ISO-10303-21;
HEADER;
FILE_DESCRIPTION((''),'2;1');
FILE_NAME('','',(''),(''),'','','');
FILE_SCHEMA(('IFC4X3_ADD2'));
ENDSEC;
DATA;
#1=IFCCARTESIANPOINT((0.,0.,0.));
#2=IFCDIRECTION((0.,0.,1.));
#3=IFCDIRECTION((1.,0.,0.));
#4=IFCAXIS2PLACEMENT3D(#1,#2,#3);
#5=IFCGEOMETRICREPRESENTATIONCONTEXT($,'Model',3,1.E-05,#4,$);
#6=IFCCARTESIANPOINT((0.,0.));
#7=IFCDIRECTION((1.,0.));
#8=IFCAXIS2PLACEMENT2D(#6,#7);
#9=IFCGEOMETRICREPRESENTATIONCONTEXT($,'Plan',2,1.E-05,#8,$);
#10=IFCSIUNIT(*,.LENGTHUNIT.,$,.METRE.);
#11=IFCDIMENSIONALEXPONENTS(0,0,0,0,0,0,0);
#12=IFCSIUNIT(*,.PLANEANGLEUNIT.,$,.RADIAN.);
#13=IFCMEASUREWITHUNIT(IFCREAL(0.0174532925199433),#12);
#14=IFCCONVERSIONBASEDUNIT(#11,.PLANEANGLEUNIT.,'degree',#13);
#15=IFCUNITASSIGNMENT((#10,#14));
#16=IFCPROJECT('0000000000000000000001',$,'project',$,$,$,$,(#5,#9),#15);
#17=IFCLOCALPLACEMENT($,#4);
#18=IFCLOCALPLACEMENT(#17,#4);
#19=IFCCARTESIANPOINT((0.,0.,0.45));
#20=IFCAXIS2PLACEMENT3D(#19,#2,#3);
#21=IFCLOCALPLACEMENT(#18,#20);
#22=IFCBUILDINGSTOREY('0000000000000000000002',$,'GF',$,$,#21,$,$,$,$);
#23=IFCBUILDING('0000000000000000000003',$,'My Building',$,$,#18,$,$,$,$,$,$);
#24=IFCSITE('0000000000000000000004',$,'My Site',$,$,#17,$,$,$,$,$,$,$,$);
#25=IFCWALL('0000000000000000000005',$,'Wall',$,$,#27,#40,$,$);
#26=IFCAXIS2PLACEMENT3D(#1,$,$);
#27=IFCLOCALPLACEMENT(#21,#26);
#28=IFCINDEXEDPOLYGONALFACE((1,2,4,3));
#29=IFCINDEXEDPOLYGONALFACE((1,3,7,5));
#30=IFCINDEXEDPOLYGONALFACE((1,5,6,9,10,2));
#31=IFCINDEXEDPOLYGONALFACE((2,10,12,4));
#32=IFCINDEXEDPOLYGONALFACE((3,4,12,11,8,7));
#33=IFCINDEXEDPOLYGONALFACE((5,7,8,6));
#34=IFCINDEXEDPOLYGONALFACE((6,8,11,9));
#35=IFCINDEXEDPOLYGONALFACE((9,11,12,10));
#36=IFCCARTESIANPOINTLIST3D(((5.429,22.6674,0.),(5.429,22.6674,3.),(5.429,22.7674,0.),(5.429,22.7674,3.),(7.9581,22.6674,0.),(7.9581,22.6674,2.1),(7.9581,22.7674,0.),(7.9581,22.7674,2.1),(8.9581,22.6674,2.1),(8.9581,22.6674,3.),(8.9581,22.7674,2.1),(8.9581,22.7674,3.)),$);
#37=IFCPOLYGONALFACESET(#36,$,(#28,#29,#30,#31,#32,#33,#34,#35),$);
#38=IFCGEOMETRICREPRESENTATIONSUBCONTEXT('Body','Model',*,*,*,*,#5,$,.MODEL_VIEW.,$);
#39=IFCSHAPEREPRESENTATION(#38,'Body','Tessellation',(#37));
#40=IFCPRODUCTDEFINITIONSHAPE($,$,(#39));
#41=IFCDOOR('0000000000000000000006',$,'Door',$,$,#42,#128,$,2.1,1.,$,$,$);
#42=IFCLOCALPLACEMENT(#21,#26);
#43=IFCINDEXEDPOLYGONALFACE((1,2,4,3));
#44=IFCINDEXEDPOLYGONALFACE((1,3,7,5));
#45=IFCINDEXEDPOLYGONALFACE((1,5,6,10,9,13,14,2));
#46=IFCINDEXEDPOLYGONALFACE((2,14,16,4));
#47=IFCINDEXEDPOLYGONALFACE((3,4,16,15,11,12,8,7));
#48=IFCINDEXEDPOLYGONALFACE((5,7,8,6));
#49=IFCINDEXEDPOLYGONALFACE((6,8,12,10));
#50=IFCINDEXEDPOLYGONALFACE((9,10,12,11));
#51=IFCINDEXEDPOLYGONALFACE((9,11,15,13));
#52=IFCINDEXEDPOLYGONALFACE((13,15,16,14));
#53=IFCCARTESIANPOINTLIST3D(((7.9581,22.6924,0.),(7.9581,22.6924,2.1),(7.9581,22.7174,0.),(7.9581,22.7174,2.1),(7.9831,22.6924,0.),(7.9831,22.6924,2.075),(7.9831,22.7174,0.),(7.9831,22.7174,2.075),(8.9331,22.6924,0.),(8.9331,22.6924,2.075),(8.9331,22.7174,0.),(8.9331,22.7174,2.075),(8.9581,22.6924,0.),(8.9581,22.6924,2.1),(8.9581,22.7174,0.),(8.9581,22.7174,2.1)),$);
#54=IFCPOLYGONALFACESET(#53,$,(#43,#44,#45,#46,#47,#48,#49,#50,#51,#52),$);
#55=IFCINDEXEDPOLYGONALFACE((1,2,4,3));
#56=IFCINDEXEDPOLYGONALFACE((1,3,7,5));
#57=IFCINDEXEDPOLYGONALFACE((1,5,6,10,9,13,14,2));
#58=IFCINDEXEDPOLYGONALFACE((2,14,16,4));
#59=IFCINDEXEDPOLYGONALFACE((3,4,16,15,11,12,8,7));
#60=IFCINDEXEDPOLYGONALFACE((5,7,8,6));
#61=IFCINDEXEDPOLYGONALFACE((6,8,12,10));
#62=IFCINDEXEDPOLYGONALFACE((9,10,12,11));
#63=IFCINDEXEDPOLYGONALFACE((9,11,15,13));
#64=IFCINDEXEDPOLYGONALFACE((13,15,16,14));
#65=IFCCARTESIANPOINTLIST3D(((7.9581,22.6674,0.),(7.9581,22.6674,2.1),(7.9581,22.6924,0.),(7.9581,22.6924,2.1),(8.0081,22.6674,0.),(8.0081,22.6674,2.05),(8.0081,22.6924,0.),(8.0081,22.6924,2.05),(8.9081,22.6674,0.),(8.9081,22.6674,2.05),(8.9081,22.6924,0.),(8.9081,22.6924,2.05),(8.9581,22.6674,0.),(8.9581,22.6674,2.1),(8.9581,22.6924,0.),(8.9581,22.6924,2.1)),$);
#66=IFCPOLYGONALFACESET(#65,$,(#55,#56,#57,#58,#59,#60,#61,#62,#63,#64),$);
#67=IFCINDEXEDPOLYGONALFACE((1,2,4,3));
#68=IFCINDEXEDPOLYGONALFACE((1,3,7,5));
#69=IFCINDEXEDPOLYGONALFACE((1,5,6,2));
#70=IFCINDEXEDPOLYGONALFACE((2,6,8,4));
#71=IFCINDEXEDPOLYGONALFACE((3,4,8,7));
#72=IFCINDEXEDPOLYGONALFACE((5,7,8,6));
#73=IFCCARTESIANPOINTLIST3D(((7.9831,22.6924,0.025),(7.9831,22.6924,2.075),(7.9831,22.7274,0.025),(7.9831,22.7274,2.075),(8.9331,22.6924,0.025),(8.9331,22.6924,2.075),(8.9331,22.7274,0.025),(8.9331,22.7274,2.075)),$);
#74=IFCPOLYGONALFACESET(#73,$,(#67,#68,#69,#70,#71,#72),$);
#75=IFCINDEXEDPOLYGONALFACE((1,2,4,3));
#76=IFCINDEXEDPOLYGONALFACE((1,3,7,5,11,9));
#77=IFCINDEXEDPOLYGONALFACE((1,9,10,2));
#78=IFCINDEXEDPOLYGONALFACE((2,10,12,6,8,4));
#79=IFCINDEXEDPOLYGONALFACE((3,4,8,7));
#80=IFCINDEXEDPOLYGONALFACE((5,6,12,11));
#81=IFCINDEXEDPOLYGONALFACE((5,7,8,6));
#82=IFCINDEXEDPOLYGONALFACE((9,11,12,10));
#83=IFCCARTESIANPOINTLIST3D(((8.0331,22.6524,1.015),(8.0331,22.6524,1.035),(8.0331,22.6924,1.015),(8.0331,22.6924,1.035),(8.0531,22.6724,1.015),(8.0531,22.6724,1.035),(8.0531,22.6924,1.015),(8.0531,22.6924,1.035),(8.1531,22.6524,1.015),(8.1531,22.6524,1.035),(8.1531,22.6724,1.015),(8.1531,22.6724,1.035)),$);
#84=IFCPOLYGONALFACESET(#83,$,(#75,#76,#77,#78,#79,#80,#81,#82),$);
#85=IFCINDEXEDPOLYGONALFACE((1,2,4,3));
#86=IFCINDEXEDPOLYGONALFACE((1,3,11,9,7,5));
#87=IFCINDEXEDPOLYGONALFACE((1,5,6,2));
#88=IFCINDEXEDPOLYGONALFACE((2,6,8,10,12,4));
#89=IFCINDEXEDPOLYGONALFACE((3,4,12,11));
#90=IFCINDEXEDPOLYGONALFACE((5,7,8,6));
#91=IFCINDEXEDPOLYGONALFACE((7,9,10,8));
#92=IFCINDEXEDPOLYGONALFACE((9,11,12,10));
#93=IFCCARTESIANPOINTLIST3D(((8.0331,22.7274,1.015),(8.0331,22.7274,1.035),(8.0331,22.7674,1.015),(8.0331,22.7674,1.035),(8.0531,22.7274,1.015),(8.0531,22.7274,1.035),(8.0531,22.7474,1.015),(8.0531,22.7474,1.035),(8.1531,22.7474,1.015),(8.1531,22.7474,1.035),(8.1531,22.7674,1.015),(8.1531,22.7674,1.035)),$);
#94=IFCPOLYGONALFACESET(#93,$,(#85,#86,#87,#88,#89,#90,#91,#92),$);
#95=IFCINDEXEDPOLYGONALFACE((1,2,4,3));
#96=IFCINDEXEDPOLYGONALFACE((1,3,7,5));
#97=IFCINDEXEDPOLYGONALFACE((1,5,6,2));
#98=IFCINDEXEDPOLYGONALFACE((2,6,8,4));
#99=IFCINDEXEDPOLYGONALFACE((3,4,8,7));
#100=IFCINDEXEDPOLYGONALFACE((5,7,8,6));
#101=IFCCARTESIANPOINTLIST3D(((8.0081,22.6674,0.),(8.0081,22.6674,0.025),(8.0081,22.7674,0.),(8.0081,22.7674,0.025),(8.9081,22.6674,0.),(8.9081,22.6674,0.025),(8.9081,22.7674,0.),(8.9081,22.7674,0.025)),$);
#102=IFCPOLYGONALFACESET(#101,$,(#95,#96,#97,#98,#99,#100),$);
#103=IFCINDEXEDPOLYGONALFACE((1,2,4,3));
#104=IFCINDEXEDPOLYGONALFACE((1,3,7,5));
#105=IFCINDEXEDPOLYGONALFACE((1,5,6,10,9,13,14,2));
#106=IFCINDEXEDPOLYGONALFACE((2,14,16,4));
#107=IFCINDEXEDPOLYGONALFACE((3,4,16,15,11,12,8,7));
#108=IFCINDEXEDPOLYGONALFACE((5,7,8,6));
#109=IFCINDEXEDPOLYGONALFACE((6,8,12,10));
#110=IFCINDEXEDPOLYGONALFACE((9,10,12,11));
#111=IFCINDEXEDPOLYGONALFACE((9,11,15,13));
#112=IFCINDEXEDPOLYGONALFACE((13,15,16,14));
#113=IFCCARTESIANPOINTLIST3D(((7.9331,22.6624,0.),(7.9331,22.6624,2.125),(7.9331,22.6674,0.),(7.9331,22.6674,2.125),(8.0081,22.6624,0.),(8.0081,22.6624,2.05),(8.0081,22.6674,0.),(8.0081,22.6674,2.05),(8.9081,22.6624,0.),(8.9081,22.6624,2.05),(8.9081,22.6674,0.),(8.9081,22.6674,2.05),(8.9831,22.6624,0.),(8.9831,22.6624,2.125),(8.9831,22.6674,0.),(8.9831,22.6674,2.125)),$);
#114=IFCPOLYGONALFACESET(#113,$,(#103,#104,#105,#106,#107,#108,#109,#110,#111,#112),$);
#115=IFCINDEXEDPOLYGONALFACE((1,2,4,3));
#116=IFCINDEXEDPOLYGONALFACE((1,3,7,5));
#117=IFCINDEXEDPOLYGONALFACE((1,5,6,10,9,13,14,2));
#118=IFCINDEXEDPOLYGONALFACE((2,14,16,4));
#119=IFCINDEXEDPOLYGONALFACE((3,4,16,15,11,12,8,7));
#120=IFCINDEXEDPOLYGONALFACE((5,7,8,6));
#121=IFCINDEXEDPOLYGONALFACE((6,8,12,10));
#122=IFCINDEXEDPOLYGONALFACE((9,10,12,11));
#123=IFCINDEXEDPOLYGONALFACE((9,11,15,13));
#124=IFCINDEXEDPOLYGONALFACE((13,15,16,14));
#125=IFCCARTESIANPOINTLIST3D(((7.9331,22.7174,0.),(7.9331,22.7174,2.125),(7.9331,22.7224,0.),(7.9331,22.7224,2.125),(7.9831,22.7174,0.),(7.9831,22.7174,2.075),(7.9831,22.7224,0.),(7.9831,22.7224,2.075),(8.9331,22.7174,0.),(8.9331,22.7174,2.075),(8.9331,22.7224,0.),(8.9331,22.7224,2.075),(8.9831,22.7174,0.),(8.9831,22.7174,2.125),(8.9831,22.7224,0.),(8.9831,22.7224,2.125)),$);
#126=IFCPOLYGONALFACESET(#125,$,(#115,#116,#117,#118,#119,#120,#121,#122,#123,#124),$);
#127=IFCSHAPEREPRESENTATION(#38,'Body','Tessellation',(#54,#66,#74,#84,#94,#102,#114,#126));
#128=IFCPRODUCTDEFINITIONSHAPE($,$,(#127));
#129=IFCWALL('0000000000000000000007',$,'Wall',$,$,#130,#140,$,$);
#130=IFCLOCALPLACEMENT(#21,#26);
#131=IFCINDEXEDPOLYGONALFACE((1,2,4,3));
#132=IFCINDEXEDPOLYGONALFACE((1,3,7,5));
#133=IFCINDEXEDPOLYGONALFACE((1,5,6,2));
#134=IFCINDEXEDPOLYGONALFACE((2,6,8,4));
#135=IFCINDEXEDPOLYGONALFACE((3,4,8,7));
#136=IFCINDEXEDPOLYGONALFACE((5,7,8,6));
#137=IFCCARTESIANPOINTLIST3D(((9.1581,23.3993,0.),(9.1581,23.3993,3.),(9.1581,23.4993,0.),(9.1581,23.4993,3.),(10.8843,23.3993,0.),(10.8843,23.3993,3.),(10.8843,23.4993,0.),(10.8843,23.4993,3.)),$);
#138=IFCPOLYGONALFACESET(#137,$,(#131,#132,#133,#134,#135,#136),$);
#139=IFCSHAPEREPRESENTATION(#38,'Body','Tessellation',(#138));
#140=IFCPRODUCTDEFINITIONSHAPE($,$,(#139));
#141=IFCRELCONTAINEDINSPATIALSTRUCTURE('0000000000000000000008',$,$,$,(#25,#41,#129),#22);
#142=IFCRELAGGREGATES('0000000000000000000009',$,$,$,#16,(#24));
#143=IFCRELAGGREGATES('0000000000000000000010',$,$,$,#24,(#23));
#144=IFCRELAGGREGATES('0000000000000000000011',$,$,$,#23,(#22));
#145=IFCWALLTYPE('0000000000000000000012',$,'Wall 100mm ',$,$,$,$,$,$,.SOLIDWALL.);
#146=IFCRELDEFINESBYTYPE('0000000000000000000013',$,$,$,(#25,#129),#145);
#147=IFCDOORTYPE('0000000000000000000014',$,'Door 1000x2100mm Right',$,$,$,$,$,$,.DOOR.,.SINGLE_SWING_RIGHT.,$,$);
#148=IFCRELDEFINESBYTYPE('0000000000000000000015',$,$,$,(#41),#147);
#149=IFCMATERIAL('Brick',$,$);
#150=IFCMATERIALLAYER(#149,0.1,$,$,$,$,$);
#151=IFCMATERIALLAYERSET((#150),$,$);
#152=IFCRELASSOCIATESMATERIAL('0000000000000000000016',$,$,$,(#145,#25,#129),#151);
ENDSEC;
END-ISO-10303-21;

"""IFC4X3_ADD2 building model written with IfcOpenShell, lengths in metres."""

from ifc_helpers import new_model, entity, si_unit, converted_unit, frame, origin_with_axes, origin_2d_with_axis, place, context, subcontext, project, spatial, line, indexed_curve, outline, extrude, shape, source, transform, mapped, material, layer, layer_set, layer_usage, type_object, type_shapes, element, fill, save


model = new_model("IFC4X3_ADD2")

# Units and contexts
model_context = context("Model", 3, precision=1e-05, world=origin_with_axes())
plan_context = context("Plan", 2, precision=1e-05, world=origin_2d_with_axis())
body_context_1 = subcontext(model_context, "Body", "Model", "MODEL_VIEW")
body_context_2 = subcontext(plan_context, "Body", "Plan", "PLAN_VIEW")
ifc_project = project(units=[si_unit("LENGTHUNIT", "METRE"), converted_unit("PLANEANGLEUNIT", "degree", entity("IfcReal", 0.0174532925199433), si_unit("PLANEANGLEUNIT", "RADIAN"), dimensions=[0, 0, 0, 0, 0, 0, 0])], contexts=[model_context, plan_context])

# Site, building, storey
site_placement = place(None, origin_with_axes())
site = spatial("IfcSite", under=ifc_project, at=site_placement, Name="My Site")
building_placement = place(site_placement, origin_with_axes())
building = spatial("IfcBuilding", under=site, at=building_placement, Name="My Building")
storey_placement = place(building_placement, frame((0.0, 0.0, 0.45), z_axis=(0.0, 0.0, 1.0), x_axis=(1.0, 0.0, 0.0)))
storey = spatial("IfcBuildingStorey", under=building, at=storey_placement, Name="GF")

# Shared definitions
ifc_material = material(Name="Brick")

# Wall, opening, door
ifc_layer_1 = layer(ifc_material, 0.1)
ifc_layer_set_1 = layer_set([ifc_layer_1])
ifc_layer_usage_1 = layer_usage(ifc_layer_set_1, "AXIS2", "POSITIVE", 0.0)
wall_type_1 = type_object("IfcWallType", Name="Wall 100mm ", PredefinedType="SOLIDWALL", material=ifc_layer_set_1)
wall_1_placement = place(storey_placement, frame((5.429, 22.6674, 0.0), z_axis=(0.0, 0.0, 1.0), x_axis=(1.0, 0.0, 0.0)))
wall_1 = element("IfcWall", 1, at=wall_1_placement, inside=storey, type_object=wall_type_1, material=ifc_layer_usage_1, Name="Wall", context=body_context_1, shape_type="SweptSolid", body=[
    extrude(outline(indexed_curve([(0.0, 0.0), (0.0, 0.1), (3.5291, 0.1), (3.5291, 0.0), (0.0, 0.0)], self_intersect=False)), origin_with_axes(), (0.0, 0.0, 1.0), 3.0),
])
shared_shape_1 = source(origin_with_axes(), body_context_1, "Body", "SweptSolid", [
    extrude(outline(indexed_curve([(0.0, 0.0), (1.0, 0.0), (1.0, 2.1), (0.0, 2.1)], segments=[line(1, 2, 3, 4, 1)])), frame((0.0, -0.6, 0.0), z_axis=(0.0, -1.0, 0.0), x_axis=(1.0, 0.0, 0.0)), (0.0, 0.0, -1.0), 1.2),
])
opening_1_placement = place(wall_1_placement, frame((2.5291, 0.0, 0.0), z_axis=(0.0, 0.0, 1.0), x_axis=(1.0, 0.0, 0.0)))
opening_1 = element("IfcOpeningElement", 2, at=opening_1_placement, cuts=wall_1, PredefinedType="OPENING", context=body_context_1, shape_type="MappedRepresentation", body=[
    mapped(shared_shape_1, transform((0.0, 0.0, 0.0), x_axis=(1.0, 0.0, 0.0), y_axis=(0.0, 1.0, 0.0), z_axis=(0.0, 0.0, 1.0), scale=1.0)),
])
door_type_1 = type_object("IfcDoorType", Name="Door 1000x2100mm Right", OperationType="SINGLE_SWING_RIGHT", PredefinedType="DOOR")
shared_shape_2 = source(origin_with_axes(), body_context_1, "Body", "SweptSolid", [
    extrude(outline(indexed_curve([(0.0, 0.0), (0.0, 2.1), (1.0, 2.1), (1.0, 0.0), (0.975, 0.0), (0.975, 2.075), (0.025, 2.075), (0.025, 0.0)], segments=[line(1, 2, 3, 4, 5, 6, 7, 8, 1)])), frame((0.0, 0.025, 0.0), z_axis=(0.0, -1.0, 0.0), x_axis=(1.0, 0.0, 0.0)), (0.0, 0.0, -1.0), 0.025),
    extrude(outline(indexed_curve([(0.0, 0.0), (0.0, 2.1), (1.0, 2.1), (1.0, 0.0), (0.95, 0.0), (0.95, 2.05), (0.05, 2.05), (0.05, 0.0)], segments=[line(1, 2, 3, 4, 5, 6, 7, 8, 1)])), frame((0.0, 0.0, 0.0), z_axis=(0.0, -1.0, 0.0), x_axis=(1.0, 0.0, 0.0)), (0.0, 0.0, -1.0), 0.025),
    extrude(outline(indexed_curve([(0.0, 0.0), (0.95, 0.0), (0.95, 0.035), (0.0, 0.035)], segments=[line(1, 2, 3, 4, 1)])), frame((0.025, 0.025, 0.025), z_axis=(0.0, 0.0, 1.0), x_axis=(1.0, 0.0, 0.0)), (0.0, 0.0, 1.0), 2.05),
    extrude(outline(indexed_curve([(0.0, 0.0), (0.0, -0.04), (0.12, -0.04), (0.12, -0.02), (0.02, -0.02), (0.02, 0.0)], segments=[line(1, 2, 3, 4, 5, 6, 1)])), frame((0.075, 0.025, 1.015), z_axis=(0.0, 0.0, 1.0), x_axis=(1.0, 0.0, 0.0)), (0.0, 0.0, 1.0), 0.02),
    extrude(outline(indexed_curve([(0.0, 0.0), (0.0, 0.04), (0.12, 0.04), (0.12, 0.02), (0.02, 0.02), (0.02, 0.0)], segments=[line(1, 2, 3, 4, 5, 6, 1)])), frame((0.075, 0.06, 1.015), z_axis=(0.0, 0.0, 1.0), x_axis=(1.0, 0.0, 0.0)), (0.0, 0.0, 1.0), 0.02),
    extrude(outline(indexed_curve([(0.0, 0.0), (0.9, 0.0), (0.9, 0.1), (0.0, 0.1)], segments=[line(1, 2, 3, 4, 1)])), frame((0.05, 0.0, 0.0), z_axis=(0.0, 0.0, 1.0), x_axis=(1.0, 0.0, 0.0)), (0.0, 0.0, 1.0), 0.025),
    extrude(outline(indexed_curve([(0.0, 0.0), (0.0, 2.125), (1.05, 2.125), (1.05, 0.0), (0.975, 0.0), (0.975, 2.05), (0.075, 2.05), (0.075, 0.0)], segments=[line(1, 2, 3, 4, 5, 6, 7, 8, 1)])), frame((-0.025, -0.005, 0.0), z_axis=(0.0, -1.0, 0.0), x_axis=(1.0, 0.0, 0.0)), (0.0, 0.0, -1.0), 0.005),
    extrude(outline(indexed_curve([(0.0, 0.0), (0.0, 2.125), (1.05, 2.125), (1.05, 0.0), (1.0, 0.0), (1.0, 2.075), (0.05, 2.075), (0.05, 0.0)], segments=[line(1, 2, 3, 4, 5, 6, 7, 8, 1)])), frame((-0.025, 0.05, 0.0), z_axis=(0.0, -1.0, 0.0), x_axis=(1.0, 0.0, 0.0)), (0.0, 0.0, -1.0), 0.005),
])
shared_shape_3 = source(origin_with_axes(), body_context_2, "Body", "Curve2D", [
    entity("IfcIndexedPolyCurve", entity("IfcCartesianPointList2D", [[0.0, 0.0], [0.0, 0.05], [0.025, 0.05], [0.025, 0.025], [0.05, 0.025], [0.05, 0.0]]), [entity("IfcLineIndex", [1, 2, 3, 4, 5, 6, 1])]),
    entity("IfcIndexedPolyCurve", entity("IfcCartesianPointList2D", [[1.0, 0.0], [1.0, 0.05], [0.975, 0.05], [0.975, 0.025], [0.95, 0.025], [0.95, 0.0]]), [entity("IfcLineIndex", [1, 2, 3, 4, 5, 6, 1])]),
    entity("IfcTrimmedCurve", entity("IfcEllipse", entity("IfcAxis2Placement2D", entity("IfcCartesianPoint", [0.94, 0.05]), entity("IfcDirection", [1.0, 0.0])), 0.915, 0.95), [entity("IfcCartesianPoint", [0.94, 1.0])], [entity("IfcCartesianPoint", [0.025, 0.05])], True, "CARTESIAN"),
    entity("IfcIndexedPolyCurve", entity("IfcCartesianPointList2D", [[0.975, 0.05], [0.94, 0.05], [0.94, 1.0], [0.975, 1.0]]), [entity("IfcLineIndex", [1, 2, 3, 4, 1])]),
])
type_shapes(door_type_1, [shared_shape_2, shared_shape_3])
door_1_placement = place(opening_1_placement, origin_with_axes())
door_1 = element("IfcDoor", 3, at=door_1_placement, inside=storey, type_object=door_type_1, Name="Door", OverallHeight=2.1, OverallWidth=1.0, shapes=[
    shape(body_context_1, "Body", "MappedRepresentation", [mapped(shared_shape_2, transform((0.0, 0.0, 0.0), x_axis=(1.0, 0.0, 0.0), y_axis=(0.0, 1.0, 0.0), z_axis=(0.0, 0.0, 1.0), scale=1.0))]),
    shape(body_context_2, "Body", "MappedRepresentation", [mapped(shared_shape_3, transform((0.0, 0.0, 0.0), x_axis=(1.0, 0.0, 0.0), y_axis=(0.0, 1.0, 0.0), z_axis=(0.0, 0.0, 1.0), scale=1.0))]),
])
fill(opening_1, door_1)

# Wall
ifc_layer_usage_2 = layer_usage(ifc_layer_set_1, "AXIS2", "POSITIVE", 0.0)
wall_2_placement = place(storey_placement, frame((9.1581, 23.3993, 0.0), z_axis=(0.0, 0.0, 1.0), x_axis=(1.0, 0.0, 0.0)))
element("IfcWall", 4, at=wall_2_placement, inside=storey, type_object=wall_type_1, material=ifc_layer_usage_2, Name="Wall", context=body_context_1, shape_type="SweptSolid", body=[
    extrude(outline(indexed_curve([(0.0, 0.0), (0.0, 0.1), (1.7262, 0.1), (1.7262, 0.0), (0.0, 0.0)], self_intersect=False)), origin_with_axes(), (0.0, 0.0, 1.0), 3.0),
])

save(model, "model.ifc")
